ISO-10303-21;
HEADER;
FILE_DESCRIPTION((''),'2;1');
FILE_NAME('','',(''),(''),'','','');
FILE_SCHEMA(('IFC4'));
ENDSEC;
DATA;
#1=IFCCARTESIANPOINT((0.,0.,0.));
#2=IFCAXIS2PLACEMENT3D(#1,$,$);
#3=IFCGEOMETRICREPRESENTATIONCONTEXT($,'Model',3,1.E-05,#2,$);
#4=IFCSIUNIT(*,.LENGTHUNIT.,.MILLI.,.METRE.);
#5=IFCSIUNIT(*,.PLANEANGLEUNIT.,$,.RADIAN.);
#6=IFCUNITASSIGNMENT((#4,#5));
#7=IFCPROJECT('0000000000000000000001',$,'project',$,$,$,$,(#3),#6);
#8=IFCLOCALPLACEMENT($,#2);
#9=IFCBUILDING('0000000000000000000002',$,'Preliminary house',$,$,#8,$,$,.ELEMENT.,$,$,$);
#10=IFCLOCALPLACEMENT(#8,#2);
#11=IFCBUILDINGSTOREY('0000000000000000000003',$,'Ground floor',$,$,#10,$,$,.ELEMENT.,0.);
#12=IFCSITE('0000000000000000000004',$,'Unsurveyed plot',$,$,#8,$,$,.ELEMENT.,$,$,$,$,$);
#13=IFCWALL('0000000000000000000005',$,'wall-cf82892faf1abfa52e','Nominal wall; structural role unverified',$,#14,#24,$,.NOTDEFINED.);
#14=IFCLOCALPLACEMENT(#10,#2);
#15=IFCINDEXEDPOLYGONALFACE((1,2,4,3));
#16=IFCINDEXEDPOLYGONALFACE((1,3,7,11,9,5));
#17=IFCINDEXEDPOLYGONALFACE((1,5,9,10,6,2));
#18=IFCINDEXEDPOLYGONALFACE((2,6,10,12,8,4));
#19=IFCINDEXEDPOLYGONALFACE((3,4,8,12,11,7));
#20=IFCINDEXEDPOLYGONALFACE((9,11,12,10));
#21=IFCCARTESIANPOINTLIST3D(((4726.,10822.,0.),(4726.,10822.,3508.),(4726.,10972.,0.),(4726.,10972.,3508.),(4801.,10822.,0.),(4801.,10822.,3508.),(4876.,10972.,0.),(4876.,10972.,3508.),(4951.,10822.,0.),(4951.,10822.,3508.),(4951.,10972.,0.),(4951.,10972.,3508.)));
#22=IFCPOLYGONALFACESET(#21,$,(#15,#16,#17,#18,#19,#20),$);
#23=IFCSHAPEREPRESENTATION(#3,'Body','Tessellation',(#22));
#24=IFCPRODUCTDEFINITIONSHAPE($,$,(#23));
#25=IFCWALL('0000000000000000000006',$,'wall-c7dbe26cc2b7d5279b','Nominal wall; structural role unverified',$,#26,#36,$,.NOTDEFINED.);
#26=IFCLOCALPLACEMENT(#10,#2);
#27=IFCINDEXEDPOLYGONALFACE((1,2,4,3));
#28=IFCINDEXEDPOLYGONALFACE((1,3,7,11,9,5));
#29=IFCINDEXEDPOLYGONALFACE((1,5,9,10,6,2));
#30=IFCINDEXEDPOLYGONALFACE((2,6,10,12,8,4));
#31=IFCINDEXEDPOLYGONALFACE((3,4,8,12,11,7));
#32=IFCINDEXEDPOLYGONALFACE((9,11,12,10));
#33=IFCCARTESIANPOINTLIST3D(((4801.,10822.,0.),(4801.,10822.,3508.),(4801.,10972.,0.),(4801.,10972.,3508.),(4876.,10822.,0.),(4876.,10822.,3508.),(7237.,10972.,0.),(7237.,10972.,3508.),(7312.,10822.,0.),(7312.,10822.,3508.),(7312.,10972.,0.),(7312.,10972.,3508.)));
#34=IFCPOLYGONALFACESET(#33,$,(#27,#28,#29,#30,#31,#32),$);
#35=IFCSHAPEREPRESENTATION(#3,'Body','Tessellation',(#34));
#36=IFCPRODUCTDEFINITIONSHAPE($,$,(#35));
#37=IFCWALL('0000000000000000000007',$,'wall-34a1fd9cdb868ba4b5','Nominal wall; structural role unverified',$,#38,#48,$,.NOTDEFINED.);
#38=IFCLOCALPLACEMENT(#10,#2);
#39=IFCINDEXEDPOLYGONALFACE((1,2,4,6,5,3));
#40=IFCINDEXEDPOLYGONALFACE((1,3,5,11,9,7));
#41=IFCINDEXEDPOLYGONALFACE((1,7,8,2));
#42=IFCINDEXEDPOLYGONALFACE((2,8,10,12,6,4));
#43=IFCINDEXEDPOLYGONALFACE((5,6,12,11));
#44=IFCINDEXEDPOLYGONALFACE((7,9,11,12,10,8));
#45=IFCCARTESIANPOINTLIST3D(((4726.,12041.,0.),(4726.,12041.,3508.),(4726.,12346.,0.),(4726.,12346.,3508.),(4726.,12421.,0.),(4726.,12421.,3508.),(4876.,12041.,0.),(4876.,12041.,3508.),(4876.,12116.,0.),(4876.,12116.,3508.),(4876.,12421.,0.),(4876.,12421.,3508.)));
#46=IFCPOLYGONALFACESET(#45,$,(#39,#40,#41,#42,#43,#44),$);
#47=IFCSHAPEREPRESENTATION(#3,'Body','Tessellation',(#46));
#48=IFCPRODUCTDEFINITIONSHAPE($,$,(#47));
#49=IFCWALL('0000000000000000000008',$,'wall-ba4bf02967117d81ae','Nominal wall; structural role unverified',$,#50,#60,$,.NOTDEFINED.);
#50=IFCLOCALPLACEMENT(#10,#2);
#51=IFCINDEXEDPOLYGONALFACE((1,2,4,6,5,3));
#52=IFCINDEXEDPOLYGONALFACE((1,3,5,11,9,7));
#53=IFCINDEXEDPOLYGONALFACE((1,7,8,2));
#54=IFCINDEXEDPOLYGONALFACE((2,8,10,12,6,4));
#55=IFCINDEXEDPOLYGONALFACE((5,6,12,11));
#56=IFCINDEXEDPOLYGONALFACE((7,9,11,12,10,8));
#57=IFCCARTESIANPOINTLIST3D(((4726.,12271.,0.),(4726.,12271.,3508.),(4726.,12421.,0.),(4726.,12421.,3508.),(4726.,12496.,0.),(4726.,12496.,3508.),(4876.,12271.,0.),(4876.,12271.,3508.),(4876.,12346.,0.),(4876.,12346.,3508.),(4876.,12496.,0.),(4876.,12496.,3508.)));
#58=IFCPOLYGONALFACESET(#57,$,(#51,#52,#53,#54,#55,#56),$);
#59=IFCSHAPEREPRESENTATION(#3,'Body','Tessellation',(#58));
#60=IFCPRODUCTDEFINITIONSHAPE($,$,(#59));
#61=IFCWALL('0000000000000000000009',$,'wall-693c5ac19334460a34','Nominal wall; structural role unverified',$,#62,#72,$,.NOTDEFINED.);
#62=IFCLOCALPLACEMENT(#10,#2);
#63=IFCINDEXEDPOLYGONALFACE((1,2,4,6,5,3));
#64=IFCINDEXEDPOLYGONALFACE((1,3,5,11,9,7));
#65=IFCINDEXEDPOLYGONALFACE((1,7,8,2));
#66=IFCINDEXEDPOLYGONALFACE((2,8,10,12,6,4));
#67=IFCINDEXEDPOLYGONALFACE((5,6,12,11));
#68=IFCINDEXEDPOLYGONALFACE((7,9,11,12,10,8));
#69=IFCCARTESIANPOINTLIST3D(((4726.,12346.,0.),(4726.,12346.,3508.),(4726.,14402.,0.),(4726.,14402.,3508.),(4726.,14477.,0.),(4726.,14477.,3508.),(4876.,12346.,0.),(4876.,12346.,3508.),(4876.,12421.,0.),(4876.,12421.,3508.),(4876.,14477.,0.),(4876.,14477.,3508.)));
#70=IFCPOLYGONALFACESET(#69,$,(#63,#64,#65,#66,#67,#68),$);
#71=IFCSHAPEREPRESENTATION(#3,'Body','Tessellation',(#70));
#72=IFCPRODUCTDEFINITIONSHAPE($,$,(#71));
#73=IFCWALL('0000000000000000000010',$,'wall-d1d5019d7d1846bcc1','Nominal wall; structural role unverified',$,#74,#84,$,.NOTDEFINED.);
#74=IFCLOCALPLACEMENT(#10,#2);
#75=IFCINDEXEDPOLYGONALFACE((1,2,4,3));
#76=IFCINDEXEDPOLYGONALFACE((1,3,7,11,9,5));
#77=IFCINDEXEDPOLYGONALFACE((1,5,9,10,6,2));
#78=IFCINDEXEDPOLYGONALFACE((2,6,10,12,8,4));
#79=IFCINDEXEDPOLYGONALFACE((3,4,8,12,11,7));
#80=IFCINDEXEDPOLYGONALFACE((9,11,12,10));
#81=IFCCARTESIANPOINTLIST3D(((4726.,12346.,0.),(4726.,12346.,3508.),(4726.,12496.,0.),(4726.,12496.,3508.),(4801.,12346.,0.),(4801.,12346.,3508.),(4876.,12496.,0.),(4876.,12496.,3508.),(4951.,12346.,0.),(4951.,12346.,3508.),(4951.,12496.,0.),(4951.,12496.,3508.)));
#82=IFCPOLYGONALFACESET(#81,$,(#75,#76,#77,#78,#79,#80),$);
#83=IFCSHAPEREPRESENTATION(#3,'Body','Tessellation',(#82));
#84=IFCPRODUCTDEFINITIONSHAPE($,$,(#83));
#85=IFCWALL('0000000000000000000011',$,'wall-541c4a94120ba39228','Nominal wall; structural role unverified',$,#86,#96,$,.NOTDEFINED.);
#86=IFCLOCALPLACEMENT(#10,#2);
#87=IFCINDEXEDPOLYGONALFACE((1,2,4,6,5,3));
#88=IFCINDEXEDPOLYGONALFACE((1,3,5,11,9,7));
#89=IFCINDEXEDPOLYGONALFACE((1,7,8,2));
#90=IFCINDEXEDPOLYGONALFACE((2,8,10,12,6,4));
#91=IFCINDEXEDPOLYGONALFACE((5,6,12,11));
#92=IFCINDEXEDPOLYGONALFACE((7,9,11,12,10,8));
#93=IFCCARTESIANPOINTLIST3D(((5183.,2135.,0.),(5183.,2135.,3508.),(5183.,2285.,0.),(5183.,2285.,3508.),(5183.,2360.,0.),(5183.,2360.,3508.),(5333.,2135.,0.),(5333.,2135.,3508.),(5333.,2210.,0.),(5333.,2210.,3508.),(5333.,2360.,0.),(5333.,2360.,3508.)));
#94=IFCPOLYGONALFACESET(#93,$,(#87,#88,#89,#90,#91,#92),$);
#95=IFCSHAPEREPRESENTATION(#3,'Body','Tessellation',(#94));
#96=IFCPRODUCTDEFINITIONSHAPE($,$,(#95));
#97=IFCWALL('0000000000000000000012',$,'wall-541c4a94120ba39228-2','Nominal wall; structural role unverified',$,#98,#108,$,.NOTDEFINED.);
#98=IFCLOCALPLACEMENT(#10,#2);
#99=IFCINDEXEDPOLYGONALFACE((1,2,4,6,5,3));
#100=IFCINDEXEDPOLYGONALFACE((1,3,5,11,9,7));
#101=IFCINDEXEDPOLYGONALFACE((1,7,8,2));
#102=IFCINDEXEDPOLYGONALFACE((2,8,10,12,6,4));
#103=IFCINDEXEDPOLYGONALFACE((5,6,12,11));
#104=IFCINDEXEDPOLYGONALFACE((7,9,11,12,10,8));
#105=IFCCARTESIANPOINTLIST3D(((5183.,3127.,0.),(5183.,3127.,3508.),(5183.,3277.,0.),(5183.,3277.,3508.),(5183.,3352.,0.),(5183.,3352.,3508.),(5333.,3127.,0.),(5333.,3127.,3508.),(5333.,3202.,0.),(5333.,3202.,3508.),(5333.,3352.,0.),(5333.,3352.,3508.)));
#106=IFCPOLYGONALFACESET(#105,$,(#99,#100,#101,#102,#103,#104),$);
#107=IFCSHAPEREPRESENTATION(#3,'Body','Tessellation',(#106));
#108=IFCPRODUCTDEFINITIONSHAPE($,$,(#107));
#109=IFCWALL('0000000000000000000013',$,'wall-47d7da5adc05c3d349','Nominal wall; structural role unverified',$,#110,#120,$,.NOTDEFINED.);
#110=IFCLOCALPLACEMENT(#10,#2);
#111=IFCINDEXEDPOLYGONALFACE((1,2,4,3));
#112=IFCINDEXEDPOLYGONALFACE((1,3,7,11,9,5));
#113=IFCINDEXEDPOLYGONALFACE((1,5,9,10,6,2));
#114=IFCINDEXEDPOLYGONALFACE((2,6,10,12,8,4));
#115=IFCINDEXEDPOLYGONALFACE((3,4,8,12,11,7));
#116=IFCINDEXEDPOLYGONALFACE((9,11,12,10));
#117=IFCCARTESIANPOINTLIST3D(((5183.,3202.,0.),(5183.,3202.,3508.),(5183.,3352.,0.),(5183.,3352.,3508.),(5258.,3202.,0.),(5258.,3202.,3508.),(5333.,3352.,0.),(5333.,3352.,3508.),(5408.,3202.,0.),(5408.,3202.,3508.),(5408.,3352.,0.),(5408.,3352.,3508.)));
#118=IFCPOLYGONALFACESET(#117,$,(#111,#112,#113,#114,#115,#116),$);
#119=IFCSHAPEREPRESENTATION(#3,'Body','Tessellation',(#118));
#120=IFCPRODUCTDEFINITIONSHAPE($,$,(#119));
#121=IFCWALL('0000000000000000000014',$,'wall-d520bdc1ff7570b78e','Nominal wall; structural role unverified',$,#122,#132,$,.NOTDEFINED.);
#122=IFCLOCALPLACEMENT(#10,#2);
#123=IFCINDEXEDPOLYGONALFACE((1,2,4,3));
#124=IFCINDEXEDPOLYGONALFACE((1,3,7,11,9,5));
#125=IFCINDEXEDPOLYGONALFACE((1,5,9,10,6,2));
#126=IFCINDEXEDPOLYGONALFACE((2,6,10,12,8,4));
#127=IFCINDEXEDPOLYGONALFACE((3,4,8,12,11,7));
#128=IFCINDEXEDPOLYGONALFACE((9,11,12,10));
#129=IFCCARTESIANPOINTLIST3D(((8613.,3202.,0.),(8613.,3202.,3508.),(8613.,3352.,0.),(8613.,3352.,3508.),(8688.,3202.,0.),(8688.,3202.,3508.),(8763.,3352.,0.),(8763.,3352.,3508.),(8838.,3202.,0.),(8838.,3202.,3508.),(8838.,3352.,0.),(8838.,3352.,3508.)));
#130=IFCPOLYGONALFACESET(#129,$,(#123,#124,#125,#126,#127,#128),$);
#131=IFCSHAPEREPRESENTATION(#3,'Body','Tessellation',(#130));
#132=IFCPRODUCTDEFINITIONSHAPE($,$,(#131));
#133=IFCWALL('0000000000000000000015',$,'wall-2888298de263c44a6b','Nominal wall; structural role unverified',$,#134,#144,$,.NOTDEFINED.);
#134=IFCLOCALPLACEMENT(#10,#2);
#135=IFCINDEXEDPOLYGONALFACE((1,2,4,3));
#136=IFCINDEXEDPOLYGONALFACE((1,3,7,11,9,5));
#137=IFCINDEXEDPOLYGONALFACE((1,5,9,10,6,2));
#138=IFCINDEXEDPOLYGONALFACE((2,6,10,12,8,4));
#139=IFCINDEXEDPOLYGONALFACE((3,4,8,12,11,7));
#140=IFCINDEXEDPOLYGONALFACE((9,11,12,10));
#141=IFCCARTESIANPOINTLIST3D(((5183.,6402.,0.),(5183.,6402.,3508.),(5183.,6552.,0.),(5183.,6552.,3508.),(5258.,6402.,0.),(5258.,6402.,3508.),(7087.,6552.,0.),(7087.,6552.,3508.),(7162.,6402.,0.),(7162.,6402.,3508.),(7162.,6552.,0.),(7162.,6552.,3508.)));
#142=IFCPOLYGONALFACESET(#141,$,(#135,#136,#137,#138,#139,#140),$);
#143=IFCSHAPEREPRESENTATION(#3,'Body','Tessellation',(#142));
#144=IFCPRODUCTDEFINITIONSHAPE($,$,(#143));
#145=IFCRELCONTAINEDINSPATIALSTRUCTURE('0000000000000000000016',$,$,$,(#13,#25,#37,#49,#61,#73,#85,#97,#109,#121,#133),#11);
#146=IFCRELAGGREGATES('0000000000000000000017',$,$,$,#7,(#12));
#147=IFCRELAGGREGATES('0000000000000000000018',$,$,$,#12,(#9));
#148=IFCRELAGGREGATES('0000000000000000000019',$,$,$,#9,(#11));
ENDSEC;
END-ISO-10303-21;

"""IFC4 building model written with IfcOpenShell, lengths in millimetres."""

from ifc_helpers import new_model, si_unit, origin, place, context, project, spatial, polyline, outline, extrude, element, save


model = new_model("IFC4")

# Units and contexts
model_context = context("Model", 3, precision=1e-05, world=origin())
ifc_project = project(units=[si_unit("LENGTHUNIT", "METRE", prefix="MILLI"), si_unit("PLANEANGLEUNIT", "RADIAN")], contexts=[model_context])

# Site, building, storey
placement_1 = place(None, origin())
site = spatial("IfcSite", under=ifc_project, at=placement_1, Name="Unsurveyed plot", CompositionType="ELEMENT")
building = spatial("IfcBuilding", under=site, at=placement_1, Name="Preliminary house", CompositionType="ELEMENT")
placement_2 = place(placement_1, origin())
storey = spatial("IfcBuildingStorey", under=building, at=placement_2, Name="Ground floor", CompositionType="ELEMENT", Elevation=0.0)

# Walls
element("IfcWall", 1, at=placement_2, inside=storey, Name="wall-cf82892faf1abfa52e", Description="Nominal wall; structural role unverified", PredefinedType="NOTDEFINED", context=model_context, shape_type="SweptSolid", body=[
    extrude(outline(polyline([(4876.0, 10972.0), (4951.0, 10972.0), (4951.0, 10822.0), (4801.0, 10822.0), (4726.0, 10822.0), (4726.0, 10972.0), (4876.0, 10972.0)])), origin(), (0.0, 0.0, 1.0), 3508.0),
])
element("IfcWall", 2, at=placement_2, inside=storey, Name="wall-c7dbe26cc2b7d5279b", Description="Nominal wall; structural role unverified", PredefinedType="NOTDEFINED", context=model_context, shape_type="SweptSolid", body=[
    extrude(outline(polyline([(7237.0, 10972.0), (7312.0, 10972.0), (7312.0, 10822.0), (4876.0, 10822.0), (4801.0, 10822.0), (4801.0, 10972.0), (7237.0, 10972.0)])), origin(), (0.0, 0.0, 1.0), 3508.0),
])
element("IfcWall", 3, at=placement_2, inside=storey, Name="wall-34a1fd9cdb868ba4b5", Description="Nominal wall; structural role unverified", PredefinedType="NOTDEFINED", context=model_context, shape_type="SweptSolid", body=[
    extrude(outline(polyline([(4726.0, 12346.0), (4726.0, 12421.0), (4876.0, 12421.0), (4876.0, 12116.0), (4876.0, 12041.0), (4726.0, 12041.0), (4726.0, 12346.0)])), origin(), (0.0, 0.0, 1.0), 3508.0),
])
element("IfcWall", 4, at=placement_2, inside=storey, Name="wall-ba4bf02967117d81ae", Description="Nominal wall; structural role unverified", PredefinedType="NOTDEFINED", context=model_context, shape_type="SweptSolid", body=[
    extrude(outline(polyline([(4726.0, 12421.0), (4726.0, 12496.0), (4876.0, 12496.0), (4876.0, 12346.0), (4876.0, 12271.0), (4726.0, 12271.0), (4726.0, 12421.0)])), origin(), (0.0, 0.0, 1.0), 3508.0),
])
element("IfcWall", 5, at=placement_2, inside=storey, Name="wall-693c5ac19334460a34", Description="Nominal wall; structural role unverified", PredefinedType="NOTDEFINED", context=model_context, shape_type="SweptSolid", body=[
    extrude(outline(polyline([(4726.0, 14402.0), (4726.0, 14477.0), (4876.0, 14477.0), (4876.0, 12421.0), (4876.0, 12346.0), (4726.0, 12346.0), (4726.0, 14402.0)])), origin(), (0.0, 0.0, 1.0), 3508.0),
])
element("IfcWall", 6, at=placement_2, inside=storey, Name="wall-d1d5019d7d1846bcc1", Description="Nominal wall; structural role unverified", PredefinedType="NOTDEFINED", context=model_context, shape_type="SweptSolid", body=[
    extrude(outline(polyline([(4876.0, 12496.0), (4951.0, 12496.0), (4951.0, 12346.0), (4801.0, 12346.0), (4726.0, 12346.0), (4726.0, 12496.0), (4876.0, 12496.0)])), origin(), (0.0, 0.0, 1.0), 3508.0),
])

# Wall
element("IfcWall", 7, at=placement_2, inside=storey, Name="wall-541c4a94120ba39228", Description="Nominal wall; structural role unverified", PredefinedType="NOTDEFINED", context=model_context, shape_type="SweptSolid", body=[
    extrude(outline(polyline([(5183.0, 2285.0), (5183.0, 2360.0), (5333.0, 2360.0), (5333.0, 2210.0), (5333.0, 2135.0), (5183.0, 2135.0), (5183.0, 2285.0)])), origin(), (0.0, 0.0, 1.0), 3508.0),
])

# Wall
element("IfcWall", 8, at=placement_2, inside=storey, Name="wall-541c4a94120ba39228-2", Description="Nominal wall; structural role unverified", PredefinedType="NOTDEFINED", context=model_context, shape_type="SweptSolid", body=[
    extrude(outline(polyline([(5183.0, 3277.0), (5183.0, 3352.0), (5333.0, 3352.0), (5333.0, 3202.0), (5333.0, 3127.0), (5183.0, 3127.0), (5183.0, 3277.0)])), origin(), (0.0, 0.0, 1.0), 3508.0),
])

# Wall
element("IfcWall", 9, at=placement_2, inside=storey, Name="wall-47d7da5adc05c3d349", Description="Nominal wall; structural role unverified", PredefinedType="NOTDEFINED", context=model_context, shape_type="SweptSolid", body=[
    extrude(outline(polyline([(5333.0, 3352.0), (5408.0, 3352.0), (5408.0, 3202.0), (5258.0, 3202.0), (5183.0, 3202.0), (5183.0, 3352.0), (5333.0, 3352.0)])), origin(), (0.0, 0.0, 1.0), 3508.0),
])

# Walls
element("IfcWall", 10, at=placement_2, inside=storey, Name="wall-d520bdc1ff7570b78e", Description="Nominal wall; structural role unverified", PredefinedType="NOTDEFINED", context=model_context, shape_type="SweptSolid", body=[
    extrude(outline(polyline([(8763.0, 3352.0), (8838.0, 3352.0), (8838.0, 3202.0), (8688.0, 3202.0), (8613.0, 3202.0), (8613.0, 3352.0), (8763.0, 3352.0)])), origin(), (0.0, 0.0, 1.0), 3508.0),
])
element("IfcWall", 11, at=placement_2, inside=storey, Name="wall-2888298de263c44a6b", Description="Nominal wall; structural role unverified", PredefinedType="NOTDEFINED", context=model_context, shape_type="SweptSolid", body=[
    extrude(outline(polyline([(7087.0, 6552.0), (7162.0, 6552.0), (7162.0, 6402.0), (5258.0, 6402.0), (5183.0, 6402.0), (5183.0, 6552.0), (7087.0, 6552.0)])), origin(), (0.0, 0.0, 1.0), 3508.0),
])

save(model, "model.ifc")
